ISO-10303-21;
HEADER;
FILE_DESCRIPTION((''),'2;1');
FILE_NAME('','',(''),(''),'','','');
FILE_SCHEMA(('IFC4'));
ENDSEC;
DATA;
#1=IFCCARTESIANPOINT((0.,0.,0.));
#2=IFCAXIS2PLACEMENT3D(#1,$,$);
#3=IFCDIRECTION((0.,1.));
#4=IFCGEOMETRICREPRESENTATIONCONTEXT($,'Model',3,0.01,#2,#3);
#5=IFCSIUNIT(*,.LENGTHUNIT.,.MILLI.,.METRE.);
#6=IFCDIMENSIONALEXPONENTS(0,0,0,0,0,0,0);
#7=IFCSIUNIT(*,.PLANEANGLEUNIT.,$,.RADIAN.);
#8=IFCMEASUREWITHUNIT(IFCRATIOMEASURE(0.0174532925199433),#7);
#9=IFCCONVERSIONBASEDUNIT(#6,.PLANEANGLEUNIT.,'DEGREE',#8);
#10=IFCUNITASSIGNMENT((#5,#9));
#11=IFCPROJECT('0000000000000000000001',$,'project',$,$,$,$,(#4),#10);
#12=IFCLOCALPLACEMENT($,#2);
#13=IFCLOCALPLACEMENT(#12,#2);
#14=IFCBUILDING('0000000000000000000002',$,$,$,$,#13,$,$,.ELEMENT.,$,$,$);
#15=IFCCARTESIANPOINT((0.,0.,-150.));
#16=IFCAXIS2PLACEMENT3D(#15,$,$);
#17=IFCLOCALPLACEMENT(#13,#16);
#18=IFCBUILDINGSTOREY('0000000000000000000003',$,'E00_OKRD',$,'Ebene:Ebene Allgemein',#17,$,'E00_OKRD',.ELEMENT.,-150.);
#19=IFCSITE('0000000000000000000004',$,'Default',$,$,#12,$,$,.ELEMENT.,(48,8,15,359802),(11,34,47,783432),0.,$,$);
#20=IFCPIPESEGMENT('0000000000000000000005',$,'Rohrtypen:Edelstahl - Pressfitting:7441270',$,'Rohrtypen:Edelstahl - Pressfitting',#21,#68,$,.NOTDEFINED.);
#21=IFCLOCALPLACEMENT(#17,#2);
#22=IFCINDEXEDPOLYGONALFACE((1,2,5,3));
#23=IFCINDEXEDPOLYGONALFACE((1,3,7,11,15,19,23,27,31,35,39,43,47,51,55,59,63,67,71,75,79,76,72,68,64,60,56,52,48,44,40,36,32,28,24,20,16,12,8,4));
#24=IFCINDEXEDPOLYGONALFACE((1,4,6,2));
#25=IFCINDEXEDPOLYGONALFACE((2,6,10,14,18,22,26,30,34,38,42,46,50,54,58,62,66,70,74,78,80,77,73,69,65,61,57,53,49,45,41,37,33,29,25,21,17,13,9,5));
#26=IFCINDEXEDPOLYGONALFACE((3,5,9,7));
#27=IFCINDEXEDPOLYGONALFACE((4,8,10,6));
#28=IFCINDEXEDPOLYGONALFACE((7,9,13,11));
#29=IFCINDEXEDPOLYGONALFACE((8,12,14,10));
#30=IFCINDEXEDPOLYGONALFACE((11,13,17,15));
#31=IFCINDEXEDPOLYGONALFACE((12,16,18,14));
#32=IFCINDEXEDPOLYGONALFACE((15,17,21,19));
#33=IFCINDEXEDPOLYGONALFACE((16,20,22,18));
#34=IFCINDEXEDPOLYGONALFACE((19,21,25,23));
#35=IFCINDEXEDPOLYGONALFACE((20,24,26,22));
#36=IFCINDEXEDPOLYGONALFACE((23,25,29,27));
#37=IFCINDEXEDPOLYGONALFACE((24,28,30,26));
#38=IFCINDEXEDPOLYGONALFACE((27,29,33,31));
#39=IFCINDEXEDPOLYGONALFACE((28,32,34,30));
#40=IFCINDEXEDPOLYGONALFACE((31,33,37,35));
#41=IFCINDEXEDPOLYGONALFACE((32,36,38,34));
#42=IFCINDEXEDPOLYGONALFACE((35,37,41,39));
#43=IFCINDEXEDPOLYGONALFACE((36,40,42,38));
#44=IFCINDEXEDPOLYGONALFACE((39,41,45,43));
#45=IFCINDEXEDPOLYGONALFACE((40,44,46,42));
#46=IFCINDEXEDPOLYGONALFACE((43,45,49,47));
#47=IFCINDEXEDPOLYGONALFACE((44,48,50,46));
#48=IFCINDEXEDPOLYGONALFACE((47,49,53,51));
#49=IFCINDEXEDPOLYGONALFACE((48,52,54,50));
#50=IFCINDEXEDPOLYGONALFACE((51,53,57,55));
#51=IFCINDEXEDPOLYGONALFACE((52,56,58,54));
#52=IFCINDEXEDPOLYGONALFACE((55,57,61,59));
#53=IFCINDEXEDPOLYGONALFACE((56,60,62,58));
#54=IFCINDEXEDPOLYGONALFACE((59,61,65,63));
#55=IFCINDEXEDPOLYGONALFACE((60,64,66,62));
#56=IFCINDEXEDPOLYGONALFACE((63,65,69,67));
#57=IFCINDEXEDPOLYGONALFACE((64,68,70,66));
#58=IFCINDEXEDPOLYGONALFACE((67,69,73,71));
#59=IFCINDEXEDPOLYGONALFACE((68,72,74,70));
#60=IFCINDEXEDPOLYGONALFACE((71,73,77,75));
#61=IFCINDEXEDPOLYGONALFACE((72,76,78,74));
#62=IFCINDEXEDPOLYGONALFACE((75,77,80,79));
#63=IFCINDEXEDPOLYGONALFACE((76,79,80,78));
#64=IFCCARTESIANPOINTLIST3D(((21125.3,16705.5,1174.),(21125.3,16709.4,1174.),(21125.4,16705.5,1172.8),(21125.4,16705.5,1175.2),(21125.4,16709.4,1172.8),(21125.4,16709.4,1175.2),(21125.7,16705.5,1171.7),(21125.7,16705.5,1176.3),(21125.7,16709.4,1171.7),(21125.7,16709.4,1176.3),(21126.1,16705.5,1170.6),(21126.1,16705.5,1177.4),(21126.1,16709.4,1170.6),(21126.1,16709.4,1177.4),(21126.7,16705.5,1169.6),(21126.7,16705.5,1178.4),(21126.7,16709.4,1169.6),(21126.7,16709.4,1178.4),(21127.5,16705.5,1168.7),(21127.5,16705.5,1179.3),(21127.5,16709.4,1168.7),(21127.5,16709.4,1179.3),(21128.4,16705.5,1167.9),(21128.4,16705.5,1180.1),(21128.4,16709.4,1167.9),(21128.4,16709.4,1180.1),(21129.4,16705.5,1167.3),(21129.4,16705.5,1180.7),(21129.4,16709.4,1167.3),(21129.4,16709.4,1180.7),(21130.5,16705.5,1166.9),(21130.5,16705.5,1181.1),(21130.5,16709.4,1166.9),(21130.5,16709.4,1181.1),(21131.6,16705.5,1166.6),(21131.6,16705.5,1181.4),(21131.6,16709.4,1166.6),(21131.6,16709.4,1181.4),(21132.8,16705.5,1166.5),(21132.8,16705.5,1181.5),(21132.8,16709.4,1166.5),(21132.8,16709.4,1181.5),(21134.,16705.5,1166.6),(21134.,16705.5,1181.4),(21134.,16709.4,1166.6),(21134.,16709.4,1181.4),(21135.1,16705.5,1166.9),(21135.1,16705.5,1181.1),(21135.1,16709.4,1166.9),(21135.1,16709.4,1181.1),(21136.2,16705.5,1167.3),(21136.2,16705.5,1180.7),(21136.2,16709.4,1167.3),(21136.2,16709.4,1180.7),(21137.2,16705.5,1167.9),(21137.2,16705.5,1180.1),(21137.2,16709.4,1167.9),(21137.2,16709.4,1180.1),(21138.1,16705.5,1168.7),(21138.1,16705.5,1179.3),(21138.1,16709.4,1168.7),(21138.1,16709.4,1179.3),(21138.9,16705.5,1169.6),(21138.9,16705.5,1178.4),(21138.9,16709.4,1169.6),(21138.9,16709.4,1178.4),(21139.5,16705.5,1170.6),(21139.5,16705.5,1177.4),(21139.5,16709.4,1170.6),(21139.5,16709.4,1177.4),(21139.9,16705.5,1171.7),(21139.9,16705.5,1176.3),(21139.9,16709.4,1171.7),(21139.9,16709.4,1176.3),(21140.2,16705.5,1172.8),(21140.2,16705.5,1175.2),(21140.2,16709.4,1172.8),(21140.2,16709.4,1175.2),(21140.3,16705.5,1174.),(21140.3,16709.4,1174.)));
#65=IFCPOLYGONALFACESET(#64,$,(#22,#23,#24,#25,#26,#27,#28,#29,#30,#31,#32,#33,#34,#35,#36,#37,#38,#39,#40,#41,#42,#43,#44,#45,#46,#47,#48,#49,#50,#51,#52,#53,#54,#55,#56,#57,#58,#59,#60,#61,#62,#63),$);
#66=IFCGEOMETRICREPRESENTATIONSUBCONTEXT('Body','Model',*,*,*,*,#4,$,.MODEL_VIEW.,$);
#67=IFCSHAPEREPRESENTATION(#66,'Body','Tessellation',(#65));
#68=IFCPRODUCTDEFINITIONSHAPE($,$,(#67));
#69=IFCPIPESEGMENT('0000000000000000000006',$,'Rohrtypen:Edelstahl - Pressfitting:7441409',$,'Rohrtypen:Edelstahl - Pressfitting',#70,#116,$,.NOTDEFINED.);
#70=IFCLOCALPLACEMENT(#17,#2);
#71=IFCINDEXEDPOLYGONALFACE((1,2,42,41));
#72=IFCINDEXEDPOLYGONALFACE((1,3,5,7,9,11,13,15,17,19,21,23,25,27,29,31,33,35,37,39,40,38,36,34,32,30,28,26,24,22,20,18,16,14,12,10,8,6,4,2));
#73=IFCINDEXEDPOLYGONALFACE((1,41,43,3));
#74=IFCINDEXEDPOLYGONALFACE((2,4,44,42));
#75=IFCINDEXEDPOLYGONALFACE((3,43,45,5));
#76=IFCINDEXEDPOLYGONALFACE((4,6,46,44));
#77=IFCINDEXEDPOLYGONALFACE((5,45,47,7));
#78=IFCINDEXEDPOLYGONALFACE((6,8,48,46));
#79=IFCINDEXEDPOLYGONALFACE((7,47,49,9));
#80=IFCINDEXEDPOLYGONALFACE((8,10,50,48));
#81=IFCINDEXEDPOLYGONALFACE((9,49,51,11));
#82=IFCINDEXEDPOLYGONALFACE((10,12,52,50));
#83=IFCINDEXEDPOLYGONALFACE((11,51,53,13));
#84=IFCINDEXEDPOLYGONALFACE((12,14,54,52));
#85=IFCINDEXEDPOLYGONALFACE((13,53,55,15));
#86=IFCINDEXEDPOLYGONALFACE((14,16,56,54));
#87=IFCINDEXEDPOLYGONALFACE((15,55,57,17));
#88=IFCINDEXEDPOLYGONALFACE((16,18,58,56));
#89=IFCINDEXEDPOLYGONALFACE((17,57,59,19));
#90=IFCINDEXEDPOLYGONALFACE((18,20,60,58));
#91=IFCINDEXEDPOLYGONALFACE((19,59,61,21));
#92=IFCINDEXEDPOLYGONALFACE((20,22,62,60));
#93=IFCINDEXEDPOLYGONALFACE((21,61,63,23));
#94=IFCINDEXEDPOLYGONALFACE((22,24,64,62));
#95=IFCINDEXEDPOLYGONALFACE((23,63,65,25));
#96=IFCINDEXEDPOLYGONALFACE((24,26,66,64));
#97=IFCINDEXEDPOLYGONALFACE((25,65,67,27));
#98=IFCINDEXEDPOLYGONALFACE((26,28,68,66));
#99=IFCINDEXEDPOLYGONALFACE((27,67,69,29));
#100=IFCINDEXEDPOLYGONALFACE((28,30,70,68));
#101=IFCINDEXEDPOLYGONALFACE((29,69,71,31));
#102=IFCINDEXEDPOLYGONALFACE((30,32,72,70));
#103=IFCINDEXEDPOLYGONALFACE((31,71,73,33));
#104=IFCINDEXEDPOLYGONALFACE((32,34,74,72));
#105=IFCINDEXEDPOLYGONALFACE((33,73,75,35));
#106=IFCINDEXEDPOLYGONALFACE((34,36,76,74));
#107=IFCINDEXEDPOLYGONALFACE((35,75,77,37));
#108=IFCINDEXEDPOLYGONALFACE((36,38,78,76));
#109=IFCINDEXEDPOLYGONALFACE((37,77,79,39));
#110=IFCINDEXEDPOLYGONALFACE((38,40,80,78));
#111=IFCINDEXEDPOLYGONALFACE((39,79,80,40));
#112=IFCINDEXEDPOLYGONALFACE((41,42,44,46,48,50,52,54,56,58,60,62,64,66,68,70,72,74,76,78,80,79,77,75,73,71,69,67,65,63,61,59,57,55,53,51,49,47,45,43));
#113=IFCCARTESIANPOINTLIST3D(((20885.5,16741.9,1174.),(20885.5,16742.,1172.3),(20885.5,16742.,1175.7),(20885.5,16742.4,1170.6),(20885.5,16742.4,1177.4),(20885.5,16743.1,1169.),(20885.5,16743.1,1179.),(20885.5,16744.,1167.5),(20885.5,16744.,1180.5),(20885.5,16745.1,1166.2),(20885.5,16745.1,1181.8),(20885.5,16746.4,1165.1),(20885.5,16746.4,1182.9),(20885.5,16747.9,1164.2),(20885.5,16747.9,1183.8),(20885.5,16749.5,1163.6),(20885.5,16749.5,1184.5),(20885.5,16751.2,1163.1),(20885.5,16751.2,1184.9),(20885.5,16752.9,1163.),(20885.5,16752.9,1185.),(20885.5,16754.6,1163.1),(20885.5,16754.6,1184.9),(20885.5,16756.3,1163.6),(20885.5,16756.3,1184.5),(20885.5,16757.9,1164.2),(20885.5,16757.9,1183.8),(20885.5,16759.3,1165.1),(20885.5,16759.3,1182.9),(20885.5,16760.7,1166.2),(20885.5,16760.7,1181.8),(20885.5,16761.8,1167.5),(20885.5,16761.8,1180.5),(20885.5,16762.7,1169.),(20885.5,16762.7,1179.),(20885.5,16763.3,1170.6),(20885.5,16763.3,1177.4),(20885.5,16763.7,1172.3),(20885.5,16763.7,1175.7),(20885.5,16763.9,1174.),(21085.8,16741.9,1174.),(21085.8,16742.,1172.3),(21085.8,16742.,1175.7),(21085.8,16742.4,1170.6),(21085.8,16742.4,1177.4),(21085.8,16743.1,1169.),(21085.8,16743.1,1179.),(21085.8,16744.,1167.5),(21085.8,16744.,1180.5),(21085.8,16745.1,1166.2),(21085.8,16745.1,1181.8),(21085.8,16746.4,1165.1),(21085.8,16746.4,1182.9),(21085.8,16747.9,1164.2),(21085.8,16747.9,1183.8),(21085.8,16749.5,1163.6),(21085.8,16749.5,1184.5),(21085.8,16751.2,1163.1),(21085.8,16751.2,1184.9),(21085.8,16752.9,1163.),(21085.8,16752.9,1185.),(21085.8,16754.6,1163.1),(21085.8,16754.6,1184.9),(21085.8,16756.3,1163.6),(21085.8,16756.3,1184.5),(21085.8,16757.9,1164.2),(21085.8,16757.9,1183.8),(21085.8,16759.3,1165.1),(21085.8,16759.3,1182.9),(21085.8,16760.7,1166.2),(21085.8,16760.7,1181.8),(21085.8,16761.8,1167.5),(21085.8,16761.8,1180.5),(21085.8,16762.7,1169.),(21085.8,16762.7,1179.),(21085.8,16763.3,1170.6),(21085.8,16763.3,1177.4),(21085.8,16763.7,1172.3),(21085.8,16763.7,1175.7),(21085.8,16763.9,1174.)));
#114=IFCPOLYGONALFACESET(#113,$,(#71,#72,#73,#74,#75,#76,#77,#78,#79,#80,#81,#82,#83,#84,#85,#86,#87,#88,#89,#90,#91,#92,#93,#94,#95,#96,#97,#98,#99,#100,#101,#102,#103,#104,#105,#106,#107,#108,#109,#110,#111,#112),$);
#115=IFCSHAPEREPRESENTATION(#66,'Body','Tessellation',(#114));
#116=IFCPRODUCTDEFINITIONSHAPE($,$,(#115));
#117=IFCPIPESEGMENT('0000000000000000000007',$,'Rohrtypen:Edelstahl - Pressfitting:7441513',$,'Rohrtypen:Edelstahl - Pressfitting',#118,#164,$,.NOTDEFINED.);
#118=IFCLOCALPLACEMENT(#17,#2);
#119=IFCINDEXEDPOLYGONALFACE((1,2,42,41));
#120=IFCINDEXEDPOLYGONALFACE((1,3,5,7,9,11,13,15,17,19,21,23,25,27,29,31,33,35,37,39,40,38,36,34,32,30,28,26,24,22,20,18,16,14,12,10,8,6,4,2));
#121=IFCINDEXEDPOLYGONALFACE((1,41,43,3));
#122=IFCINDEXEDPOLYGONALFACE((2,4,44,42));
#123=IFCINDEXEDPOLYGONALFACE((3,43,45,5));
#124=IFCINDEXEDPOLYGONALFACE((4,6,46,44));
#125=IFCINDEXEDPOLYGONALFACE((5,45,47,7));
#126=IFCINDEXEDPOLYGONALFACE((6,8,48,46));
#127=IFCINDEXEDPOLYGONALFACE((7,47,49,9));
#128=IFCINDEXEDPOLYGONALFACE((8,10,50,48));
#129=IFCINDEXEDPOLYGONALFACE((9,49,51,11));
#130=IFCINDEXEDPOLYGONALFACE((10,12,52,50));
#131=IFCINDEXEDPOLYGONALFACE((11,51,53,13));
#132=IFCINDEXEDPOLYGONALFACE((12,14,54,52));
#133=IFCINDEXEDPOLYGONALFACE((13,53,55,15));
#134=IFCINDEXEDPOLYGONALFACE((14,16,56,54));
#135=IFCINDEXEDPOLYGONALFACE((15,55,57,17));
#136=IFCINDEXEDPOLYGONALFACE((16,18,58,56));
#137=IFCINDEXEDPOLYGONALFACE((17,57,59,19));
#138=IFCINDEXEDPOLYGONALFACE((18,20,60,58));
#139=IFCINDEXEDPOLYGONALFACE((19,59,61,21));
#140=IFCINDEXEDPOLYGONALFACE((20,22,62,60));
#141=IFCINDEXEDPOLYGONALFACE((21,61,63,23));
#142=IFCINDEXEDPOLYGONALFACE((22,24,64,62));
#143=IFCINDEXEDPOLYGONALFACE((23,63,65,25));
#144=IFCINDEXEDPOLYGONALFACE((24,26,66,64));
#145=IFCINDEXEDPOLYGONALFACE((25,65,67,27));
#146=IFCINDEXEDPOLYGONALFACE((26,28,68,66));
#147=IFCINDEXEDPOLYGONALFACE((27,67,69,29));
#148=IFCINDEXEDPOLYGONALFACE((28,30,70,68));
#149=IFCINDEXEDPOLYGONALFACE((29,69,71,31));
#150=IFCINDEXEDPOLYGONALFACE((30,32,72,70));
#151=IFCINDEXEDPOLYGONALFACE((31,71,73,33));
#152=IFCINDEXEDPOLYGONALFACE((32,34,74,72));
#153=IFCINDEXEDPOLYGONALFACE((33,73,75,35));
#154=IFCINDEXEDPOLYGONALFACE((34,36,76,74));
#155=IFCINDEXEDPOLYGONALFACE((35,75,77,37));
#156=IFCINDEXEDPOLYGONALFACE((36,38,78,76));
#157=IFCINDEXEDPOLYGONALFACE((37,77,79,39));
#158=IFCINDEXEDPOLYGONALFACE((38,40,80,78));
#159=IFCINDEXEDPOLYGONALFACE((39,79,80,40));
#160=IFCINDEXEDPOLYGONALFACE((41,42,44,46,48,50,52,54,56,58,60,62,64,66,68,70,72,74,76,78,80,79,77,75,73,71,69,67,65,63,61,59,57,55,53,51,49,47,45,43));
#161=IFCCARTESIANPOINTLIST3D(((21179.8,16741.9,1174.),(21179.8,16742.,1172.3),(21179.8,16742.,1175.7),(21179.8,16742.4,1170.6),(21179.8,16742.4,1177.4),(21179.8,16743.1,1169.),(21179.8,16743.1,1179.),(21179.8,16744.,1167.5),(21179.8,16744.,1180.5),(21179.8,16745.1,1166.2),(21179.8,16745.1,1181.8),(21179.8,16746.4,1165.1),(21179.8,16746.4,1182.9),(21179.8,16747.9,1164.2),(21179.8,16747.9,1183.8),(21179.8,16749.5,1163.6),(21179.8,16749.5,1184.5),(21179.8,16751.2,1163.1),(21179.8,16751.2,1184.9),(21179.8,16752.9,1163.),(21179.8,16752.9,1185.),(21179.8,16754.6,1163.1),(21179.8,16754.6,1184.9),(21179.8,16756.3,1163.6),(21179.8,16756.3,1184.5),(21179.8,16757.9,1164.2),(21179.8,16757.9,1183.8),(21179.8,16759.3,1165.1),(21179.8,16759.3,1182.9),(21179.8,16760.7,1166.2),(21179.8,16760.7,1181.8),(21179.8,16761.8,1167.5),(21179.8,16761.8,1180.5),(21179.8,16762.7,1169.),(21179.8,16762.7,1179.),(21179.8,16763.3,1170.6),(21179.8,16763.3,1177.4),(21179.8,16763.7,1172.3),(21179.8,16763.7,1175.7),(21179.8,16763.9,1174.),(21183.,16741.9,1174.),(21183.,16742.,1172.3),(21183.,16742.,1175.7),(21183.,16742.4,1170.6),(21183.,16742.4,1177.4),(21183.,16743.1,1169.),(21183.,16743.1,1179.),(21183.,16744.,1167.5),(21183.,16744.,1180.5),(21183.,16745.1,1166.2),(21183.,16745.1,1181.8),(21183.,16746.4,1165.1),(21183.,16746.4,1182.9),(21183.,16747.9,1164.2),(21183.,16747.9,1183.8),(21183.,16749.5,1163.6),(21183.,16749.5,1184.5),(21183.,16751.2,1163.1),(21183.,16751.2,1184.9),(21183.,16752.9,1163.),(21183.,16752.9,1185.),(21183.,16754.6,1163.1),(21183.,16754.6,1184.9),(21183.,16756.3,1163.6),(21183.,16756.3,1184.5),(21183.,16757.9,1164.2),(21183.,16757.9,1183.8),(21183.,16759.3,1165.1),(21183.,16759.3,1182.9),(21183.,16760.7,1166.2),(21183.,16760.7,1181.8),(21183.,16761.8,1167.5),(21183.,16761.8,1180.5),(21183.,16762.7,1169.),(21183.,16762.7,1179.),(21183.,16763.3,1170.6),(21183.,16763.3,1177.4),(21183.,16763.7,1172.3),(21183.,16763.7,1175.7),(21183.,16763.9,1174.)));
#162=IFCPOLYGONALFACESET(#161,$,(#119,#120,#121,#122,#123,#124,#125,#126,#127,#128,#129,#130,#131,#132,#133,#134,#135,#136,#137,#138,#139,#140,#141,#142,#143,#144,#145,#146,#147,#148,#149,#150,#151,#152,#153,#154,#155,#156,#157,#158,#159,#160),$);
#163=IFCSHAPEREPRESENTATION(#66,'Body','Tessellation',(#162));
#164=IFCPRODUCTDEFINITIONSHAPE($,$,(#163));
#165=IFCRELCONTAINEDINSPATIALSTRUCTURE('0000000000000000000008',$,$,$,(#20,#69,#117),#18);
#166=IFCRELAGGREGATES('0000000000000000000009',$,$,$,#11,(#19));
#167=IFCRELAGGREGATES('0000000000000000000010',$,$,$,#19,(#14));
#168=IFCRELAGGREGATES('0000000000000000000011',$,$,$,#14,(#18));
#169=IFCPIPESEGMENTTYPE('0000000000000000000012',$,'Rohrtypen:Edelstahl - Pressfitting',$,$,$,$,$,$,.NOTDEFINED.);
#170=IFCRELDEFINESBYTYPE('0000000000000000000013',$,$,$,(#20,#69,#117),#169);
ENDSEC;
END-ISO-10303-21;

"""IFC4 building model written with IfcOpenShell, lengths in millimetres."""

from ifc_helpers import new_model, entity, si_unit, converted_unit, direction, frame, origin, place, context, subcontext, project, spatial, indexed_curve, outline, extrude, type_object, element, save


model = new_model("IFC4")

# Units and contexts
model_context = context("Model", 3, precision=0.01, world=origin(), true_north=direction((0.0, 1.0)))
body_context = subcontext(model_context, "Body", "Model", "MODEL_VIEW")
ifc_project = project(units=[si_unit("LENGTHUNIT", "METRE", prefix="MILLI"), converted_unit("PLANEANGLEUNIT", "DEGREE", entity("IfcRatioMeasure", 0.0174532925199433), si_unit("PLANEANGLEUNIT", "RADIAN"), dimensions=[0, 0, 0, 0, 0, 0, 0])], contexts=[model_context])

# Site, building, storey
site_placement = place(None, origin())
site = spatial("IfcSite", under=ifc_project, at=site_placement, Name="Default", CompositionType="ELEMENT", RefLatitude=(48, 8, 15, 359802), RefLongitude=(11, 34, 47, 783432), RefElevation=0.0)
building_placement = place(site_placement, origin())
building = spatial("IfcBuilding", under=site, at=building_placement, CompositionType="ELEMENT")
storey_placement = place(building_placement, frame((0.0, 0.0, -150.0)))
storey = spatial("IfcBuildingStorey", under=building, at=storey_placement, Name="E00_OKRD", ObjectType="Ebene:Ebene Allgemein", LongName="E00_OKRD", CompositionType="ELEMENT", Elevation=-150.0)

# Pipe segments
pipe_segment_type_1 = type_object("IfcPipeSegmentType", Name="Rohrtypen:Edelstahl - Pressfitting", PredefinedType="NOTDEFINED")
pipe_segment_1_placement = place(storey_placement, origin())
element("IfcPipeSegment", 1, at=pipe_segment_1_placement, inside=storey, type_object=pipe_segment_type_1, Name="Rohrtypen:Edelstahl - Pressfitting:7441270", ObjectType="Rohrtypen:Edelstahl - Pressfitting", PredefinedType="NOTDEFINED", context=body_context, shape_type="SweptSolid", body=[
    extrude(outline(indexed_curve([(7.5, 0.0), (7.4, 1.2), (7.1, 2.3), (6.7, 3.4), (6.1, 4.4), (5.3, 5.3), (4.4, 6.1), (3.4, 6.7), (2.3, 7.1), (1.2, 7.4), (0.0, 7.5), (-1.2, 7.4), (-2.3, 7.1), (-3.4, 6.7), (-4.4, 6.1), (-5.3, 5.3), (-6.1, 4.4), (-6.7, 3.4), (-7.1, 2.3), (-7.4, 1.2), (-7.5, 0.0), (-7.4, -1.2), (-7.1, -2.3), (-6.7, -3.4), (-6.1, -4.4), (-5.3, -5.3), (-4.4, -6.1), (-3.4, -6.7), (-2.3, -7.1), (-1.2, -7.4), (0.0, -7.5), (1.2, -7.4), (2.3, -7.1), (3.4, -6.7), (4.4, -6.1), (5.3, -5.3), (6.1, -4.4), (6.7, -3.4), (7.1, -2.3), (7.4, -1.2), (7.5, 0.0)], self_intersect=False)), frame((21132.8, 16705.5, 1174.0), z_axis=(0.0, 1.0, 0.0), x_axis=(-1.0, 0.0, 0.0)), (0.0, 0.0, 1.0), 3.9),
])
pipe_segment_2_placement = place(storey_placement, origin())
element("IfcPipeSegment", 2, at=pipe_segment_2_placement, inside=storey, type_object=pipe_segment_type_1, Name="Rohrtypen:Edelstahl - Pressfitting:7441409", ObjectType="Rohrtypen:Edelstahl - Pressfitting", PredefinedType="NOTDEFINED", context=body_context, shape_type="SweptSolid", body=[
    extrude(outline(indexed_curve([(11.0, 0.0), (10.9, 1.7), (10.5, 3.4), (9.8, 5.0), (8.9, 6.5), (7.8, 7.8), (6.5, 8.9), (5.0, 9.8), (3.4, 10.5), (1.7, 10.9), (0.0, 11.0), (-1.7, 10.9), (-3.4, 10.5), (-5.0, 9.8), (-6.5, 8.9), (-7.8, 7.8), (-8.9, 6.5), (-9.8, 5.0), (-10.5, 3.4), (-10.9, 1.7), (-11.0, 0.0), (-10.9, -1.7), (-10.5, -3.4), (-9.8, -5.0), (-8.9, -6.5), (-7.8, -7.8), (-6.5, -8.9), (-5.0, -9.8), (-3.4, -10.5), (-1.7, -10.9), (0.0, -11.0), (1.7, -10.9), (3.4, -10.5), (5.0, -9.8), (6.5, -8.9), (7.8, -7.8), (8.9, -6.5), (9.8, -5.0), (10.5, -3.4), (10.9, -1.7), (11.0, 0.0)], self_intersect=False)), frame((20885.5, 16752.9, 1174.0), z_axis=(1.0, -0.000002, 0.0), x_axis=(-0.000002, -1.0, 0.0)), (0.0, 0.0, 1.0), 200.3),
])
pipe_segment_3_placement = place(storey_placement, origin())
element("IfcPipeSegment", 3, at=pipe_segment_3_placement, inside=storey, type_object=pipe_segment_type_1, Name="Rohrtypen:Edelstahl - Pressfitting:7441513", ObjectType="Rohrtypen:Edelstahl - Pressfitting", PredefinedType="NOTDEFINED", context=body_context, shape_type="SweptSolid", body=[
    extrude(outline(indexed_curve([(11.0, 0.0), (10.9, 1.7), (10.5, 3.4), (9.8, 5.0), (8.9, 6.5), (7.8, 7.8), (6.5, 8.9), (5.0, 9.8), (3.4, 10.5), (1.7, 10.9), (0.0, 11.0), (-1.7, 10.9), (-3.4, 10.5), (-5.0, 9.8), (-6.5, 8.9), (-7.8, 7.8), (-8.9, 6.5), (-9.8, 5.0), (-10.5, 3.4), (-10.9, 1.7), (-11.0, 0.0), (-10.9, -1.7), (-10.5, -3.4), (-9.8, -5.0), (-8.9, -6.5), (-7.8, -7.8), (-6.5, -8.9), (-5.0, -9.8), (-3.4, -10.5), (-1.7, -10.9), (0.0, -11.0), (1.7, -10.9), (3.4, -10.5), (5.0, -9.8), (6.5, -8.9), (7.8, -7.8), (8.9, -6.5), (9.8, -5.0), (10.5, -3.4), (10.9, -1.7), (11.0, 0.0)], self_intersect=False)), frame((21179.8, 16752.9, 1174.0), z_axis=(1.0, -0.000027, 0.0), x_axis=(-0.000027, -1.0, 0.0)), (0.0, 0.0, 1.0), 3.2),
])

save(model, "model.ifc")
